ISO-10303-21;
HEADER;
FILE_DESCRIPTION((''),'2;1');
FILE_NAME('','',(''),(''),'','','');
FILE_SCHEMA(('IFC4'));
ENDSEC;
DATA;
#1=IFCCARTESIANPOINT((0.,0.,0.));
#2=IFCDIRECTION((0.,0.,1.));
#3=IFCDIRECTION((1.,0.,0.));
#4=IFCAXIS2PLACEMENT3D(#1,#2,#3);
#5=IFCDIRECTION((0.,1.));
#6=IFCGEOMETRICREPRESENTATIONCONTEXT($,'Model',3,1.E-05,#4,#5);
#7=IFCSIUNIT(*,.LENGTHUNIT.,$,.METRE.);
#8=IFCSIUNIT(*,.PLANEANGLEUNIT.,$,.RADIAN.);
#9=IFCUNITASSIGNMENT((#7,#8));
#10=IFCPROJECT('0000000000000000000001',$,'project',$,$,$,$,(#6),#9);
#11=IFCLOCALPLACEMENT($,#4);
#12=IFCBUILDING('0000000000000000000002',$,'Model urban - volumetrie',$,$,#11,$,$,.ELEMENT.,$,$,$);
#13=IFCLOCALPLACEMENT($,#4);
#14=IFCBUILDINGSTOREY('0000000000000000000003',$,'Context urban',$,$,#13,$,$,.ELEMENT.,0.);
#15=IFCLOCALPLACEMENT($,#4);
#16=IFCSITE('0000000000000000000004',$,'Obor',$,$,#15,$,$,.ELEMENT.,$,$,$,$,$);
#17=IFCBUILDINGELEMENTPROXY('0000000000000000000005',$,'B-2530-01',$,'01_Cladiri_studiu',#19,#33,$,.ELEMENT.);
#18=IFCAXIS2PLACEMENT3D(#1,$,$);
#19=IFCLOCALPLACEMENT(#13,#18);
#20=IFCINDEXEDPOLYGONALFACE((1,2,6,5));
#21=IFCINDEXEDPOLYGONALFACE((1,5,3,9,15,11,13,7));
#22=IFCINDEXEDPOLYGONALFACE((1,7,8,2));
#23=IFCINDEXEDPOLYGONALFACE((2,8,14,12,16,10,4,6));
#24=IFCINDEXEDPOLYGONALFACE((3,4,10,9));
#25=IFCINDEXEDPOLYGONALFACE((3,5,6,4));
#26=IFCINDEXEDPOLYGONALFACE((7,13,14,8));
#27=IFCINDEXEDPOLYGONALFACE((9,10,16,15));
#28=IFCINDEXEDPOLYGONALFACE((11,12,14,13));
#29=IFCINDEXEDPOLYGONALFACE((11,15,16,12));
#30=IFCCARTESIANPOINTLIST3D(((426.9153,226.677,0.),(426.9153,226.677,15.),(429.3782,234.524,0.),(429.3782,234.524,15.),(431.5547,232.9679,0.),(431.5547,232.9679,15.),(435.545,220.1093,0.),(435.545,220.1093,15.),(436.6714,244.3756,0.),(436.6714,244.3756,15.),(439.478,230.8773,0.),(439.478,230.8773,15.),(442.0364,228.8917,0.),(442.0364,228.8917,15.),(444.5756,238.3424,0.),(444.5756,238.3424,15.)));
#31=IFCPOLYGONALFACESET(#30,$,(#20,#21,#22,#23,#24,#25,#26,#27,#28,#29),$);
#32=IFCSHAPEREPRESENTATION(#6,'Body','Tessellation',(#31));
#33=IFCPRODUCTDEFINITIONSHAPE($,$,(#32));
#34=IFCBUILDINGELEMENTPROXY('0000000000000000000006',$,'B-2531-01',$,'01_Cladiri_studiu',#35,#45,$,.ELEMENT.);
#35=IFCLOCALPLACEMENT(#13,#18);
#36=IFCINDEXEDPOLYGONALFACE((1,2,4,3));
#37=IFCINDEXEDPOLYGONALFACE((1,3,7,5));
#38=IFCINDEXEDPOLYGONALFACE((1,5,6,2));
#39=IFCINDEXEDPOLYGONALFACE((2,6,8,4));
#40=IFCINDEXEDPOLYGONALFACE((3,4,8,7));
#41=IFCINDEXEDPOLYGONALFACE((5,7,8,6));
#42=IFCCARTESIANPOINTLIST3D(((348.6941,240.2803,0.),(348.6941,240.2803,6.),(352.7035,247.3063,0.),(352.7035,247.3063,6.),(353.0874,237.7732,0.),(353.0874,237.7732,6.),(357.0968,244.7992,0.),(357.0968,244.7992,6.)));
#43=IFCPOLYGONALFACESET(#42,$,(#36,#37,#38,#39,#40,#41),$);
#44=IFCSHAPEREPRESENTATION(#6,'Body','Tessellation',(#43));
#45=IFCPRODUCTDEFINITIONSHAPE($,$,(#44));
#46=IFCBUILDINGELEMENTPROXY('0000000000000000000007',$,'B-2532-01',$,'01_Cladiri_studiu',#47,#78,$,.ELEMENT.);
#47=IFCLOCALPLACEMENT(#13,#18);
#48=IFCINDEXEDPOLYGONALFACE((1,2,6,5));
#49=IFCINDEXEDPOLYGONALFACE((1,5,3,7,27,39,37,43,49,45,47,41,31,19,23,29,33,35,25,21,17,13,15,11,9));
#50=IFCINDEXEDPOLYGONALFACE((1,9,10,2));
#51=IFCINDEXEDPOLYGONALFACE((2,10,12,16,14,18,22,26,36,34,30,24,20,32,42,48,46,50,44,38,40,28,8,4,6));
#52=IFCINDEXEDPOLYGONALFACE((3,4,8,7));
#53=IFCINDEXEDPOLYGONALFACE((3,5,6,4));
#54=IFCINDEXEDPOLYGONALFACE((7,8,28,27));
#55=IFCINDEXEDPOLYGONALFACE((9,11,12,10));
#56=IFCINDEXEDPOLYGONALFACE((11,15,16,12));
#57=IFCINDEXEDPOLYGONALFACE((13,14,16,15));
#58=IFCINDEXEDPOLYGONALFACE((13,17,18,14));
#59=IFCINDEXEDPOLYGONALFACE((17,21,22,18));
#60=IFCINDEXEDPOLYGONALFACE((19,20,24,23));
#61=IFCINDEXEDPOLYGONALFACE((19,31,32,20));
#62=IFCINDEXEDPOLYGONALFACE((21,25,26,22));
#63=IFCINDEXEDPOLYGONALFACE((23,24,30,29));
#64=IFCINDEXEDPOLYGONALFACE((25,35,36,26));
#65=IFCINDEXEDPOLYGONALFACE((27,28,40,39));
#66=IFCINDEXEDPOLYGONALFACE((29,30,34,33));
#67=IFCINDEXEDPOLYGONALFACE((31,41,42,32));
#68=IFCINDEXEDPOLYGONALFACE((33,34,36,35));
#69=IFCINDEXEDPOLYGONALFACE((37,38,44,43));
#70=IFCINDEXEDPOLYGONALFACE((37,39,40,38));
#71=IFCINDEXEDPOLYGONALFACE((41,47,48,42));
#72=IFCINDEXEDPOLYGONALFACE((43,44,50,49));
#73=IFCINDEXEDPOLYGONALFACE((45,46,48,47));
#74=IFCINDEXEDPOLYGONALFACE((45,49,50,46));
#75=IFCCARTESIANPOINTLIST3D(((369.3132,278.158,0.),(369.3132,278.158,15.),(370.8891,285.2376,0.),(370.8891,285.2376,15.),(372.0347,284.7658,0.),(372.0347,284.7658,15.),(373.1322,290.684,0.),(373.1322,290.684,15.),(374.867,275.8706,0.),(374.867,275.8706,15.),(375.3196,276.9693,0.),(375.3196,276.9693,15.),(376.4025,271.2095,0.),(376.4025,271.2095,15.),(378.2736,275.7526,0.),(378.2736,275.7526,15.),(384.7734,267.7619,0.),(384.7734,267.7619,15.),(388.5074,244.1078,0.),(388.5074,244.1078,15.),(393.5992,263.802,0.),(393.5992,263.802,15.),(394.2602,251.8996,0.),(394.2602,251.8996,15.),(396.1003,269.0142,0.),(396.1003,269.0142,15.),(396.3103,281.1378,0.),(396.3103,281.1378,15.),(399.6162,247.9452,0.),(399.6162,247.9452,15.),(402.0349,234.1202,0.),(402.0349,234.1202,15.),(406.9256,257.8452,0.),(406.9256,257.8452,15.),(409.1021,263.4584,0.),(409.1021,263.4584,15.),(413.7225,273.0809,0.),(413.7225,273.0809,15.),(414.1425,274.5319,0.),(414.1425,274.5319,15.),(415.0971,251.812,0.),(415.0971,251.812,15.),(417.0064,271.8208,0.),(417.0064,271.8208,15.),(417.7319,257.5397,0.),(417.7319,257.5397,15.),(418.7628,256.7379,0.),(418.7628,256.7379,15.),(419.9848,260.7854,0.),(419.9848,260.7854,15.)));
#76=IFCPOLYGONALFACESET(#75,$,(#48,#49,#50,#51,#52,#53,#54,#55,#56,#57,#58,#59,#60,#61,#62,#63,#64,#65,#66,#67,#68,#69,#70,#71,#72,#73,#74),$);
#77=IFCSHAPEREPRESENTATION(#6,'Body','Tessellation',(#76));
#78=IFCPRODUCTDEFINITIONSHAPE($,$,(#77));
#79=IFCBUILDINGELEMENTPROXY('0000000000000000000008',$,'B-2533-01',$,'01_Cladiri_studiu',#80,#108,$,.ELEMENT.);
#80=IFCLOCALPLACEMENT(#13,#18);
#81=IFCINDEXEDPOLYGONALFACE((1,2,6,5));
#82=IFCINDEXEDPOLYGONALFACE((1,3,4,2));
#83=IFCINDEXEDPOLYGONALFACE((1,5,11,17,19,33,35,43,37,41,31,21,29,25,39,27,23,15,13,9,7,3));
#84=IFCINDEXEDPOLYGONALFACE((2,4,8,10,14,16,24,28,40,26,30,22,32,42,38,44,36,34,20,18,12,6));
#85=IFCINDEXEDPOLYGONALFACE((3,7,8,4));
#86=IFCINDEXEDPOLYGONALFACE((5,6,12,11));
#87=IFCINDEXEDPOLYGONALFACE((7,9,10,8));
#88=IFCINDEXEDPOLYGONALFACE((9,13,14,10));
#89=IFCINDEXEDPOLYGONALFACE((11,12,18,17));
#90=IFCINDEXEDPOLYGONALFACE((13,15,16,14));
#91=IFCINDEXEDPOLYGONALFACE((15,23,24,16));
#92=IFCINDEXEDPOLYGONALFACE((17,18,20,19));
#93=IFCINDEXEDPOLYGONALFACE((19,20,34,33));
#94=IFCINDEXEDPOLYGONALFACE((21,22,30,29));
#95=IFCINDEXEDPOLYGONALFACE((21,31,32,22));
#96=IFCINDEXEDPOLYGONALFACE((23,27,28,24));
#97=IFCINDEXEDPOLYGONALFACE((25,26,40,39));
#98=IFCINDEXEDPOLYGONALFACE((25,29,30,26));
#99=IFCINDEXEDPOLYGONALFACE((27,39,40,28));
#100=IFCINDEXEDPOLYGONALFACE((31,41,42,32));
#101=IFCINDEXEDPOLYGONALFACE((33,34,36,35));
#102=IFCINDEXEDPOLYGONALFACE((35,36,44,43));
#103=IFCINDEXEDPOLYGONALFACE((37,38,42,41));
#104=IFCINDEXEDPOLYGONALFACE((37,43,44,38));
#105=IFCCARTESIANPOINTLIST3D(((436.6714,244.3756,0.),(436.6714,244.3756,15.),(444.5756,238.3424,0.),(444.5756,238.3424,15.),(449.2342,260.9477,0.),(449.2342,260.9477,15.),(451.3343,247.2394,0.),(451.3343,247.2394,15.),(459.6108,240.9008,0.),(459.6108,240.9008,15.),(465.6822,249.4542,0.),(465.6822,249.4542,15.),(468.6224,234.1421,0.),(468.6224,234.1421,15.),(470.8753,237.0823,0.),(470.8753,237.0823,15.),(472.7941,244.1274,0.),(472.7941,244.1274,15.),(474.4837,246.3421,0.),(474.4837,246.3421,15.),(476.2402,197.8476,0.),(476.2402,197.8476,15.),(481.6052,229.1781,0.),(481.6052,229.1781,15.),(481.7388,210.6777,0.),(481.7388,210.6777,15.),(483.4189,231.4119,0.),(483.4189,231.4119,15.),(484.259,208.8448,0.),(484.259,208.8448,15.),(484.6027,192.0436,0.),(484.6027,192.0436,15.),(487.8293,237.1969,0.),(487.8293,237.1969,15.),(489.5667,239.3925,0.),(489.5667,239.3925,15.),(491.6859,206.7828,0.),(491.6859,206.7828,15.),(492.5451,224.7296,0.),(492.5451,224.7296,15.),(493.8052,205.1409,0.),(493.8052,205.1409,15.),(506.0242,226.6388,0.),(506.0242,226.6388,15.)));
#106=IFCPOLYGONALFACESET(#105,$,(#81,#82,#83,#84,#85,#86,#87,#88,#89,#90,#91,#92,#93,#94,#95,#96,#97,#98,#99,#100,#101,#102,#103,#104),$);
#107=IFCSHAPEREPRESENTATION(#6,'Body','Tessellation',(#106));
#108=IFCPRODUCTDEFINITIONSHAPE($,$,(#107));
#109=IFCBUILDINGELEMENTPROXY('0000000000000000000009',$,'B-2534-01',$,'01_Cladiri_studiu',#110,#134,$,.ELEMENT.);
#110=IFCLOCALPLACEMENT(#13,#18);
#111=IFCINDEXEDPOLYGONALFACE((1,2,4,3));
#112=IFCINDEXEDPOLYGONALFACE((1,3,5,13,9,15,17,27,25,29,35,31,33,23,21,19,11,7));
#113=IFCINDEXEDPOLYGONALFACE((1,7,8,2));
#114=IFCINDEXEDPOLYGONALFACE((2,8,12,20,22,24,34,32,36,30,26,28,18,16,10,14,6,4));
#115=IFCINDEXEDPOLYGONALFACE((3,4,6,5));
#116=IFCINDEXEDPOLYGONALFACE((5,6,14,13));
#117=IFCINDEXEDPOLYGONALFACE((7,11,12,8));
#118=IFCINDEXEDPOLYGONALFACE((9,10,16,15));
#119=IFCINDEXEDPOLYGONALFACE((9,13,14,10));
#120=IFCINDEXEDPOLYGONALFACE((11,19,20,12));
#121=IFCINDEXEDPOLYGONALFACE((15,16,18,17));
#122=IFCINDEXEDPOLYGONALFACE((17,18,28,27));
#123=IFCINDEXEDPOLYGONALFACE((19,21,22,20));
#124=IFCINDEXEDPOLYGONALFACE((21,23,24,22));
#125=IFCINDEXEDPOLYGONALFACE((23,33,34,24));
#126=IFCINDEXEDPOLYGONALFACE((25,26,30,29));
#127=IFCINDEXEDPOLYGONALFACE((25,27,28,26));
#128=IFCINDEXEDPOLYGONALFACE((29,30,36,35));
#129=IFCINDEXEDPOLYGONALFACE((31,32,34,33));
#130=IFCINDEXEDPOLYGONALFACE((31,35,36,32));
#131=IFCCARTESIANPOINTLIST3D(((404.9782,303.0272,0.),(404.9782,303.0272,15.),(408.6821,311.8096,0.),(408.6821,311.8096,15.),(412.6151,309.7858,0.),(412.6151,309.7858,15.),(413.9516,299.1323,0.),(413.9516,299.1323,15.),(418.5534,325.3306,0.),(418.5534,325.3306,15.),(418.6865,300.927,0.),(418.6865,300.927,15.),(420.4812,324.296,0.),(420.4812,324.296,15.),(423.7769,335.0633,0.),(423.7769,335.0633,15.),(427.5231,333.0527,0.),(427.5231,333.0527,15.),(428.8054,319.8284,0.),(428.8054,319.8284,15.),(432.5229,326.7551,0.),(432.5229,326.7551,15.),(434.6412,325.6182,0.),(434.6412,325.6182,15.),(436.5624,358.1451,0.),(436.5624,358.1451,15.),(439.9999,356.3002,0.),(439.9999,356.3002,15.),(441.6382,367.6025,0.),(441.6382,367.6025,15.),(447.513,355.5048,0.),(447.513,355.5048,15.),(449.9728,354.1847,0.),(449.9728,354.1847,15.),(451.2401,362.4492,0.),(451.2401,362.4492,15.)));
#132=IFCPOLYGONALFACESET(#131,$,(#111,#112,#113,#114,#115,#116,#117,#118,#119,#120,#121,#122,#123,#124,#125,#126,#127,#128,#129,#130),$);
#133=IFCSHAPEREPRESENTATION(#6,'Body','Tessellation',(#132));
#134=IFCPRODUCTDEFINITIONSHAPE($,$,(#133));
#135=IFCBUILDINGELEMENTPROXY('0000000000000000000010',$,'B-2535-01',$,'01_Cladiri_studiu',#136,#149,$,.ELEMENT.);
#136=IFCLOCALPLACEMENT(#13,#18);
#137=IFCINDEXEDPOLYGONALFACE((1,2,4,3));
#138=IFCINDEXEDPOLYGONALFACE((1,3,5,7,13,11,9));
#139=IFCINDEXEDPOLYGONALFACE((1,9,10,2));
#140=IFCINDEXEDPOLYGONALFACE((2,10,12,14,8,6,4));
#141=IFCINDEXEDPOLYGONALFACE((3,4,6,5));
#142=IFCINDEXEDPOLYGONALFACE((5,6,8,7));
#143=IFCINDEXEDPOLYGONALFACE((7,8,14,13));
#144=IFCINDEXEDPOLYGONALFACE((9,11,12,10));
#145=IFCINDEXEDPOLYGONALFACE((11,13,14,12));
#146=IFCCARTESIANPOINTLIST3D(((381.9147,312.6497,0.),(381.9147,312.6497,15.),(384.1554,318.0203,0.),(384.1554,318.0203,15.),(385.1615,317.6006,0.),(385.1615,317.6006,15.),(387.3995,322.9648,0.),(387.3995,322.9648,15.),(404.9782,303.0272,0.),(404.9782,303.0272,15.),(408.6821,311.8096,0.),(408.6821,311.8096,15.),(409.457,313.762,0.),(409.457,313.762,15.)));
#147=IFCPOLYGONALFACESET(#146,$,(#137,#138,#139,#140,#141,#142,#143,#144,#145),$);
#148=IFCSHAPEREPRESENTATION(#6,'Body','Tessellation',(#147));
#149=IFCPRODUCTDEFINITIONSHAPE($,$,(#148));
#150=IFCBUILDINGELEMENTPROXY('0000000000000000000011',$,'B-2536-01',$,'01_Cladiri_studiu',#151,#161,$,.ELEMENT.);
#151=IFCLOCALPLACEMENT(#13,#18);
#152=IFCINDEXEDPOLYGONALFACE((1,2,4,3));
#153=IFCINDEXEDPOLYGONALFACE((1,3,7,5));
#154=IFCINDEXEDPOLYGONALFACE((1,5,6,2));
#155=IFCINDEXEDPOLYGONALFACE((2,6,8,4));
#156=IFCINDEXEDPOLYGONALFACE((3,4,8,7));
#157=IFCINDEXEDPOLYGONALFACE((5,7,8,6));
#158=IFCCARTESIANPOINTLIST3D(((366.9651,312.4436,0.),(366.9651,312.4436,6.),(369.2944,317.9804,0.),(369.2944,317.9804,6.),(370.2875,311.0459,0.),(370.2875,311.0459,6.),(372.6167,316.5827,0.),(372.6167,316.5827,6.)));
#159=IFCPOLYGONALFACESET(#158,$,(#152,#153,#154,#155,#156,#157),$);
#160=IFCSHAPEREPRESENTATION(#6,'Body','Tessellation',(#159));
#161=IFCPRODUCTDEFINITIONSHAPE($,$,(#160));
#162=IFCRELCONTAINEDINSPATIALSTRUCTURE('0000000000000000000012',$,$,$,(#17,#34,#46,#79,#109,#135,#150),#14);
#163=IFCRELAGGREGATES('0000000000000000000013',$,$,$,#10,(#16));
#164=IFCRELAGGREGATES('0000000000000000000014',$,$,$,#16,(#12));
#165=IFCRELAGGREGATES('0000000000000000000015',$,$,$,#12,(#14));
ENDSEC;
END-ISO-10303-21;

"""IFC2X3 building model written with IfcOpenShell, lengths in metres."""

from ifc_helpers import new_model, si_unit, direction, origin_with_axes, place, context, project, spatial, polyline, outline, extrude, element, save


model = new_model("IFC2X3")

# Units and contexts
model_context = context("Model", 3, precision=1e-05, world=origin_with_axes(), true_north=direction((0.0, 1.0)))
ifc_project = project(units=[si_unit("LENGTHUNIT", "METRE"), si_unit("PLANEANGLEUNIT", "RADIAN")], contexts=[model_context])

# Site, building, storey
site_placement = place(None, origin_with_axes())
site = spatial("IfcSite", under=ifc_project, at=site_placement, Name="Obor", CompositionType="ELEMENT")
building_placement = place(None, origin_with_axes())
building = spatial("IfcBuilding", under=site, at=building_placement, Name="Model urban - volumetrie", CompositionType="ELEMENT")
storey_placement = place(None, origin_with_axes())
storey = spatial("IfcBuildingStorey", under=building, at=storey_placement, Name="Context urban", CompositionType="ELEMENT", Elevation=0.0)

# Building element proxies
proxy_1_placement = place(None, origin_with_axes())
element("IfcBuildingElementProxy", 1, at=proxy_1_placement, inside=storey, Name="B-2530-01", ObjectType="01_Cladiri_studiu", CompositionType="ELEMENT", context=model_context, shape_type="SweptSolid", body=[
    extrude(outline(polyline([(431.5547, 232.9679), (426.9153, 226.677), (435.545, 220.1093), (442.0364, 228.8917), (439.478, 230.8773), (444.5756, 238.3424), (436.6714, 244.3756), (429.3782, 234.524), (431.5547, 232.9679)])), origin_with_axes(), (0.0, 0.0, 1.0), 15.0),
])
proxy_2_placement = place(None, origin_with_axes())
element("IfcBuildingElementProxy", 2, at=proxy_2_placement, inside=storey, Name="B-2531-01", ObjectType="01_Cladiri_studiu", CompositionType="ELEMENT", context=model_context, shape_type="SweptSolid", body=[
    extrude(outline(polyline([(348.6941, 240.2803), (353.0874, 237.7732), (357.0968, 244.7992), (352.7035, 247.3063), (348.6941, 240.2803)])), origin_with_axes(), (0.0, 0.0, 1.0), 6.0),
])
proxy_3_placement = place(None, origin_with_axes())
element("IfcBuildingElementProxy", 3, at=proxy_3_placement, inside=storey, Name="B-2532-01", ObjectType="01_Cladiri_studiu", CompositionType="ELEMENT", context=model_context, shape_type="SweptSolid", body=[
    extrude(outline(polyline([(375.3196, 276.9693), (378.2736, 275.7526), (376.4025, 271.2095), (384.7734, 267.7619), (393.5992, 263.802), (396.1003, 269.0142), (409.1021, 263.4584), (406.9256, 257.8452), (399.6162, 247.9452), (394.2602, 251.8996), (388.5074, 244.1078), (402.0349, 234.1202), (415.0971, 251.812), (418.7628, 256.7379), (417.7319, 257.5397), (419.9848, 260.7854), (417.0064, 271.8208), (413.7225, 273.0809), (414.1425, 274.5319), (396.3103, 281.1378), (373.1322, 290.684), (370.8891, 285.2376), (372.0347, 284.7658), (369.3132, 278.158), (374.867, 275.8706), (375.3196, 276.9693)]), holes=[polyline([(391.8065, 270.2027), (396.3103, 281.1378), (391.8065, 270.2027), (386.6529, 272.3253), (391.8065, 270.2027)])]), origin_with_axes(), (0.0, 0.0, 1.0), 15.0),
])
proxy_4_placement = place(None, origin_with_axes())
element("IfcBuildingElementProxy", 4, at=proxy_4_placement, inside=storey, Name="B-2533-01", ObjectType="01_Cladiri_studiu", CompositionType="ELEMENT", context=model_context, shape_type="SweptSolid", body=[
    extrude(outline(polyline([(487.8293, 237.1969), (474.4837, 246.3421), (472.7941, 244.1274), (465.6822, 249.4542), (449.2342, 260.9477), (436.6714, 244.3756), (444.5756, 238.3424), (451.3343, 247.2394), (459.6108, 240.9008), (468.6224, 234.1421), (470.8753, 237.0823), (481.6052, 229.1781), (483.4189, 231.4119), (492.5451, 224.7296), (481.7388, 210.6777), (484.259, 208.8448), (476.2402, 197.8476), (484.6027, 192.0436), (493.8052, 205.1409), (491.6859, 206.7828), (506.0242, 226.6388), (489.5667, 239.3925), (487.8293, 237.1969)])), origin_with_axes(), (0.0, 0.0, 1.0), 15.0),
])
proxy_5_placement = place(None, origin_with_axes())
element("IfcBuildingElementProxy", 5, at=proxy_5_placement, inside=storey, Name="B-2534-01", ObjectType="01_Cladiri_studiu", CompositionType="ELEMENT", context=model_context, shape_type="SweptSolid", body=[
    extrude(outline(polyline([(436.5624, 358.1451), (439.9999, 356.3002), (427.5231, 333.0527), (423.7769, 335.0633), (418.5534, 325.3306), (420.4812, 324.296), (412.6151, 309.7858), (408.6821, 311.8096), (404.9782, 303.0272), (413.9516, 299.1323), (418.6865, 300.927), (428.8054, 319.8284), (432.5229, 326.7551), (434.6412, 325.6182), (449.9728, 354.1847), (447.513, 355.5048), (451.2401, 362.4492), (441.6382, 367.6025), (436.5624, 358.1451)])), origin_with_axes(), (0.0, 0.0, 1.0), 15.0),
])
proxy_6_placement = place(None, origin_with_axes())
element("IfcBuildingElementProxy", 6, at=proxy_6_placement, inside=storey, Name="B-2535-01", ObjectType="01_Cladiri_studiu", CompositionType="ELEMENT", context=model_context, shape_type="SweptSolid", body=[
    extrude(outline(polyline([(381.9147, 312.6497), (404.9782, 303.0272), (408.6821, 311.8096), (409.457, 313.762), (387.3995, 322.9648), (385.1615, 317.6006), (384.1554, 318.0203), (381.9147, 312.6497)])), origin_with_axes(), (0.0, 0.0, 1.0), 15.0),
])
proxy_7_placement = place(None, origin_with_axes())
element("IfcBuildingElementProxy", 7, at=proxy_7_placement, inside=storey, Name="B-2536-01", ObjectType="01_Cladiri_studiu", CompositionType="ELEMENT", context=model_context, shape_type="SweptSolid", body=[
    extrude(outline(polyline([(366.9651, 312.4436), (370.2875, 311.0459), (372.6167, 316.5827), (369.2944, 317.9804), (366.9651, 312.4436)])), origin_with_axes(), (0.0, 0.0, 1.0), 6.0),
])

save(model, "model.ifc")
